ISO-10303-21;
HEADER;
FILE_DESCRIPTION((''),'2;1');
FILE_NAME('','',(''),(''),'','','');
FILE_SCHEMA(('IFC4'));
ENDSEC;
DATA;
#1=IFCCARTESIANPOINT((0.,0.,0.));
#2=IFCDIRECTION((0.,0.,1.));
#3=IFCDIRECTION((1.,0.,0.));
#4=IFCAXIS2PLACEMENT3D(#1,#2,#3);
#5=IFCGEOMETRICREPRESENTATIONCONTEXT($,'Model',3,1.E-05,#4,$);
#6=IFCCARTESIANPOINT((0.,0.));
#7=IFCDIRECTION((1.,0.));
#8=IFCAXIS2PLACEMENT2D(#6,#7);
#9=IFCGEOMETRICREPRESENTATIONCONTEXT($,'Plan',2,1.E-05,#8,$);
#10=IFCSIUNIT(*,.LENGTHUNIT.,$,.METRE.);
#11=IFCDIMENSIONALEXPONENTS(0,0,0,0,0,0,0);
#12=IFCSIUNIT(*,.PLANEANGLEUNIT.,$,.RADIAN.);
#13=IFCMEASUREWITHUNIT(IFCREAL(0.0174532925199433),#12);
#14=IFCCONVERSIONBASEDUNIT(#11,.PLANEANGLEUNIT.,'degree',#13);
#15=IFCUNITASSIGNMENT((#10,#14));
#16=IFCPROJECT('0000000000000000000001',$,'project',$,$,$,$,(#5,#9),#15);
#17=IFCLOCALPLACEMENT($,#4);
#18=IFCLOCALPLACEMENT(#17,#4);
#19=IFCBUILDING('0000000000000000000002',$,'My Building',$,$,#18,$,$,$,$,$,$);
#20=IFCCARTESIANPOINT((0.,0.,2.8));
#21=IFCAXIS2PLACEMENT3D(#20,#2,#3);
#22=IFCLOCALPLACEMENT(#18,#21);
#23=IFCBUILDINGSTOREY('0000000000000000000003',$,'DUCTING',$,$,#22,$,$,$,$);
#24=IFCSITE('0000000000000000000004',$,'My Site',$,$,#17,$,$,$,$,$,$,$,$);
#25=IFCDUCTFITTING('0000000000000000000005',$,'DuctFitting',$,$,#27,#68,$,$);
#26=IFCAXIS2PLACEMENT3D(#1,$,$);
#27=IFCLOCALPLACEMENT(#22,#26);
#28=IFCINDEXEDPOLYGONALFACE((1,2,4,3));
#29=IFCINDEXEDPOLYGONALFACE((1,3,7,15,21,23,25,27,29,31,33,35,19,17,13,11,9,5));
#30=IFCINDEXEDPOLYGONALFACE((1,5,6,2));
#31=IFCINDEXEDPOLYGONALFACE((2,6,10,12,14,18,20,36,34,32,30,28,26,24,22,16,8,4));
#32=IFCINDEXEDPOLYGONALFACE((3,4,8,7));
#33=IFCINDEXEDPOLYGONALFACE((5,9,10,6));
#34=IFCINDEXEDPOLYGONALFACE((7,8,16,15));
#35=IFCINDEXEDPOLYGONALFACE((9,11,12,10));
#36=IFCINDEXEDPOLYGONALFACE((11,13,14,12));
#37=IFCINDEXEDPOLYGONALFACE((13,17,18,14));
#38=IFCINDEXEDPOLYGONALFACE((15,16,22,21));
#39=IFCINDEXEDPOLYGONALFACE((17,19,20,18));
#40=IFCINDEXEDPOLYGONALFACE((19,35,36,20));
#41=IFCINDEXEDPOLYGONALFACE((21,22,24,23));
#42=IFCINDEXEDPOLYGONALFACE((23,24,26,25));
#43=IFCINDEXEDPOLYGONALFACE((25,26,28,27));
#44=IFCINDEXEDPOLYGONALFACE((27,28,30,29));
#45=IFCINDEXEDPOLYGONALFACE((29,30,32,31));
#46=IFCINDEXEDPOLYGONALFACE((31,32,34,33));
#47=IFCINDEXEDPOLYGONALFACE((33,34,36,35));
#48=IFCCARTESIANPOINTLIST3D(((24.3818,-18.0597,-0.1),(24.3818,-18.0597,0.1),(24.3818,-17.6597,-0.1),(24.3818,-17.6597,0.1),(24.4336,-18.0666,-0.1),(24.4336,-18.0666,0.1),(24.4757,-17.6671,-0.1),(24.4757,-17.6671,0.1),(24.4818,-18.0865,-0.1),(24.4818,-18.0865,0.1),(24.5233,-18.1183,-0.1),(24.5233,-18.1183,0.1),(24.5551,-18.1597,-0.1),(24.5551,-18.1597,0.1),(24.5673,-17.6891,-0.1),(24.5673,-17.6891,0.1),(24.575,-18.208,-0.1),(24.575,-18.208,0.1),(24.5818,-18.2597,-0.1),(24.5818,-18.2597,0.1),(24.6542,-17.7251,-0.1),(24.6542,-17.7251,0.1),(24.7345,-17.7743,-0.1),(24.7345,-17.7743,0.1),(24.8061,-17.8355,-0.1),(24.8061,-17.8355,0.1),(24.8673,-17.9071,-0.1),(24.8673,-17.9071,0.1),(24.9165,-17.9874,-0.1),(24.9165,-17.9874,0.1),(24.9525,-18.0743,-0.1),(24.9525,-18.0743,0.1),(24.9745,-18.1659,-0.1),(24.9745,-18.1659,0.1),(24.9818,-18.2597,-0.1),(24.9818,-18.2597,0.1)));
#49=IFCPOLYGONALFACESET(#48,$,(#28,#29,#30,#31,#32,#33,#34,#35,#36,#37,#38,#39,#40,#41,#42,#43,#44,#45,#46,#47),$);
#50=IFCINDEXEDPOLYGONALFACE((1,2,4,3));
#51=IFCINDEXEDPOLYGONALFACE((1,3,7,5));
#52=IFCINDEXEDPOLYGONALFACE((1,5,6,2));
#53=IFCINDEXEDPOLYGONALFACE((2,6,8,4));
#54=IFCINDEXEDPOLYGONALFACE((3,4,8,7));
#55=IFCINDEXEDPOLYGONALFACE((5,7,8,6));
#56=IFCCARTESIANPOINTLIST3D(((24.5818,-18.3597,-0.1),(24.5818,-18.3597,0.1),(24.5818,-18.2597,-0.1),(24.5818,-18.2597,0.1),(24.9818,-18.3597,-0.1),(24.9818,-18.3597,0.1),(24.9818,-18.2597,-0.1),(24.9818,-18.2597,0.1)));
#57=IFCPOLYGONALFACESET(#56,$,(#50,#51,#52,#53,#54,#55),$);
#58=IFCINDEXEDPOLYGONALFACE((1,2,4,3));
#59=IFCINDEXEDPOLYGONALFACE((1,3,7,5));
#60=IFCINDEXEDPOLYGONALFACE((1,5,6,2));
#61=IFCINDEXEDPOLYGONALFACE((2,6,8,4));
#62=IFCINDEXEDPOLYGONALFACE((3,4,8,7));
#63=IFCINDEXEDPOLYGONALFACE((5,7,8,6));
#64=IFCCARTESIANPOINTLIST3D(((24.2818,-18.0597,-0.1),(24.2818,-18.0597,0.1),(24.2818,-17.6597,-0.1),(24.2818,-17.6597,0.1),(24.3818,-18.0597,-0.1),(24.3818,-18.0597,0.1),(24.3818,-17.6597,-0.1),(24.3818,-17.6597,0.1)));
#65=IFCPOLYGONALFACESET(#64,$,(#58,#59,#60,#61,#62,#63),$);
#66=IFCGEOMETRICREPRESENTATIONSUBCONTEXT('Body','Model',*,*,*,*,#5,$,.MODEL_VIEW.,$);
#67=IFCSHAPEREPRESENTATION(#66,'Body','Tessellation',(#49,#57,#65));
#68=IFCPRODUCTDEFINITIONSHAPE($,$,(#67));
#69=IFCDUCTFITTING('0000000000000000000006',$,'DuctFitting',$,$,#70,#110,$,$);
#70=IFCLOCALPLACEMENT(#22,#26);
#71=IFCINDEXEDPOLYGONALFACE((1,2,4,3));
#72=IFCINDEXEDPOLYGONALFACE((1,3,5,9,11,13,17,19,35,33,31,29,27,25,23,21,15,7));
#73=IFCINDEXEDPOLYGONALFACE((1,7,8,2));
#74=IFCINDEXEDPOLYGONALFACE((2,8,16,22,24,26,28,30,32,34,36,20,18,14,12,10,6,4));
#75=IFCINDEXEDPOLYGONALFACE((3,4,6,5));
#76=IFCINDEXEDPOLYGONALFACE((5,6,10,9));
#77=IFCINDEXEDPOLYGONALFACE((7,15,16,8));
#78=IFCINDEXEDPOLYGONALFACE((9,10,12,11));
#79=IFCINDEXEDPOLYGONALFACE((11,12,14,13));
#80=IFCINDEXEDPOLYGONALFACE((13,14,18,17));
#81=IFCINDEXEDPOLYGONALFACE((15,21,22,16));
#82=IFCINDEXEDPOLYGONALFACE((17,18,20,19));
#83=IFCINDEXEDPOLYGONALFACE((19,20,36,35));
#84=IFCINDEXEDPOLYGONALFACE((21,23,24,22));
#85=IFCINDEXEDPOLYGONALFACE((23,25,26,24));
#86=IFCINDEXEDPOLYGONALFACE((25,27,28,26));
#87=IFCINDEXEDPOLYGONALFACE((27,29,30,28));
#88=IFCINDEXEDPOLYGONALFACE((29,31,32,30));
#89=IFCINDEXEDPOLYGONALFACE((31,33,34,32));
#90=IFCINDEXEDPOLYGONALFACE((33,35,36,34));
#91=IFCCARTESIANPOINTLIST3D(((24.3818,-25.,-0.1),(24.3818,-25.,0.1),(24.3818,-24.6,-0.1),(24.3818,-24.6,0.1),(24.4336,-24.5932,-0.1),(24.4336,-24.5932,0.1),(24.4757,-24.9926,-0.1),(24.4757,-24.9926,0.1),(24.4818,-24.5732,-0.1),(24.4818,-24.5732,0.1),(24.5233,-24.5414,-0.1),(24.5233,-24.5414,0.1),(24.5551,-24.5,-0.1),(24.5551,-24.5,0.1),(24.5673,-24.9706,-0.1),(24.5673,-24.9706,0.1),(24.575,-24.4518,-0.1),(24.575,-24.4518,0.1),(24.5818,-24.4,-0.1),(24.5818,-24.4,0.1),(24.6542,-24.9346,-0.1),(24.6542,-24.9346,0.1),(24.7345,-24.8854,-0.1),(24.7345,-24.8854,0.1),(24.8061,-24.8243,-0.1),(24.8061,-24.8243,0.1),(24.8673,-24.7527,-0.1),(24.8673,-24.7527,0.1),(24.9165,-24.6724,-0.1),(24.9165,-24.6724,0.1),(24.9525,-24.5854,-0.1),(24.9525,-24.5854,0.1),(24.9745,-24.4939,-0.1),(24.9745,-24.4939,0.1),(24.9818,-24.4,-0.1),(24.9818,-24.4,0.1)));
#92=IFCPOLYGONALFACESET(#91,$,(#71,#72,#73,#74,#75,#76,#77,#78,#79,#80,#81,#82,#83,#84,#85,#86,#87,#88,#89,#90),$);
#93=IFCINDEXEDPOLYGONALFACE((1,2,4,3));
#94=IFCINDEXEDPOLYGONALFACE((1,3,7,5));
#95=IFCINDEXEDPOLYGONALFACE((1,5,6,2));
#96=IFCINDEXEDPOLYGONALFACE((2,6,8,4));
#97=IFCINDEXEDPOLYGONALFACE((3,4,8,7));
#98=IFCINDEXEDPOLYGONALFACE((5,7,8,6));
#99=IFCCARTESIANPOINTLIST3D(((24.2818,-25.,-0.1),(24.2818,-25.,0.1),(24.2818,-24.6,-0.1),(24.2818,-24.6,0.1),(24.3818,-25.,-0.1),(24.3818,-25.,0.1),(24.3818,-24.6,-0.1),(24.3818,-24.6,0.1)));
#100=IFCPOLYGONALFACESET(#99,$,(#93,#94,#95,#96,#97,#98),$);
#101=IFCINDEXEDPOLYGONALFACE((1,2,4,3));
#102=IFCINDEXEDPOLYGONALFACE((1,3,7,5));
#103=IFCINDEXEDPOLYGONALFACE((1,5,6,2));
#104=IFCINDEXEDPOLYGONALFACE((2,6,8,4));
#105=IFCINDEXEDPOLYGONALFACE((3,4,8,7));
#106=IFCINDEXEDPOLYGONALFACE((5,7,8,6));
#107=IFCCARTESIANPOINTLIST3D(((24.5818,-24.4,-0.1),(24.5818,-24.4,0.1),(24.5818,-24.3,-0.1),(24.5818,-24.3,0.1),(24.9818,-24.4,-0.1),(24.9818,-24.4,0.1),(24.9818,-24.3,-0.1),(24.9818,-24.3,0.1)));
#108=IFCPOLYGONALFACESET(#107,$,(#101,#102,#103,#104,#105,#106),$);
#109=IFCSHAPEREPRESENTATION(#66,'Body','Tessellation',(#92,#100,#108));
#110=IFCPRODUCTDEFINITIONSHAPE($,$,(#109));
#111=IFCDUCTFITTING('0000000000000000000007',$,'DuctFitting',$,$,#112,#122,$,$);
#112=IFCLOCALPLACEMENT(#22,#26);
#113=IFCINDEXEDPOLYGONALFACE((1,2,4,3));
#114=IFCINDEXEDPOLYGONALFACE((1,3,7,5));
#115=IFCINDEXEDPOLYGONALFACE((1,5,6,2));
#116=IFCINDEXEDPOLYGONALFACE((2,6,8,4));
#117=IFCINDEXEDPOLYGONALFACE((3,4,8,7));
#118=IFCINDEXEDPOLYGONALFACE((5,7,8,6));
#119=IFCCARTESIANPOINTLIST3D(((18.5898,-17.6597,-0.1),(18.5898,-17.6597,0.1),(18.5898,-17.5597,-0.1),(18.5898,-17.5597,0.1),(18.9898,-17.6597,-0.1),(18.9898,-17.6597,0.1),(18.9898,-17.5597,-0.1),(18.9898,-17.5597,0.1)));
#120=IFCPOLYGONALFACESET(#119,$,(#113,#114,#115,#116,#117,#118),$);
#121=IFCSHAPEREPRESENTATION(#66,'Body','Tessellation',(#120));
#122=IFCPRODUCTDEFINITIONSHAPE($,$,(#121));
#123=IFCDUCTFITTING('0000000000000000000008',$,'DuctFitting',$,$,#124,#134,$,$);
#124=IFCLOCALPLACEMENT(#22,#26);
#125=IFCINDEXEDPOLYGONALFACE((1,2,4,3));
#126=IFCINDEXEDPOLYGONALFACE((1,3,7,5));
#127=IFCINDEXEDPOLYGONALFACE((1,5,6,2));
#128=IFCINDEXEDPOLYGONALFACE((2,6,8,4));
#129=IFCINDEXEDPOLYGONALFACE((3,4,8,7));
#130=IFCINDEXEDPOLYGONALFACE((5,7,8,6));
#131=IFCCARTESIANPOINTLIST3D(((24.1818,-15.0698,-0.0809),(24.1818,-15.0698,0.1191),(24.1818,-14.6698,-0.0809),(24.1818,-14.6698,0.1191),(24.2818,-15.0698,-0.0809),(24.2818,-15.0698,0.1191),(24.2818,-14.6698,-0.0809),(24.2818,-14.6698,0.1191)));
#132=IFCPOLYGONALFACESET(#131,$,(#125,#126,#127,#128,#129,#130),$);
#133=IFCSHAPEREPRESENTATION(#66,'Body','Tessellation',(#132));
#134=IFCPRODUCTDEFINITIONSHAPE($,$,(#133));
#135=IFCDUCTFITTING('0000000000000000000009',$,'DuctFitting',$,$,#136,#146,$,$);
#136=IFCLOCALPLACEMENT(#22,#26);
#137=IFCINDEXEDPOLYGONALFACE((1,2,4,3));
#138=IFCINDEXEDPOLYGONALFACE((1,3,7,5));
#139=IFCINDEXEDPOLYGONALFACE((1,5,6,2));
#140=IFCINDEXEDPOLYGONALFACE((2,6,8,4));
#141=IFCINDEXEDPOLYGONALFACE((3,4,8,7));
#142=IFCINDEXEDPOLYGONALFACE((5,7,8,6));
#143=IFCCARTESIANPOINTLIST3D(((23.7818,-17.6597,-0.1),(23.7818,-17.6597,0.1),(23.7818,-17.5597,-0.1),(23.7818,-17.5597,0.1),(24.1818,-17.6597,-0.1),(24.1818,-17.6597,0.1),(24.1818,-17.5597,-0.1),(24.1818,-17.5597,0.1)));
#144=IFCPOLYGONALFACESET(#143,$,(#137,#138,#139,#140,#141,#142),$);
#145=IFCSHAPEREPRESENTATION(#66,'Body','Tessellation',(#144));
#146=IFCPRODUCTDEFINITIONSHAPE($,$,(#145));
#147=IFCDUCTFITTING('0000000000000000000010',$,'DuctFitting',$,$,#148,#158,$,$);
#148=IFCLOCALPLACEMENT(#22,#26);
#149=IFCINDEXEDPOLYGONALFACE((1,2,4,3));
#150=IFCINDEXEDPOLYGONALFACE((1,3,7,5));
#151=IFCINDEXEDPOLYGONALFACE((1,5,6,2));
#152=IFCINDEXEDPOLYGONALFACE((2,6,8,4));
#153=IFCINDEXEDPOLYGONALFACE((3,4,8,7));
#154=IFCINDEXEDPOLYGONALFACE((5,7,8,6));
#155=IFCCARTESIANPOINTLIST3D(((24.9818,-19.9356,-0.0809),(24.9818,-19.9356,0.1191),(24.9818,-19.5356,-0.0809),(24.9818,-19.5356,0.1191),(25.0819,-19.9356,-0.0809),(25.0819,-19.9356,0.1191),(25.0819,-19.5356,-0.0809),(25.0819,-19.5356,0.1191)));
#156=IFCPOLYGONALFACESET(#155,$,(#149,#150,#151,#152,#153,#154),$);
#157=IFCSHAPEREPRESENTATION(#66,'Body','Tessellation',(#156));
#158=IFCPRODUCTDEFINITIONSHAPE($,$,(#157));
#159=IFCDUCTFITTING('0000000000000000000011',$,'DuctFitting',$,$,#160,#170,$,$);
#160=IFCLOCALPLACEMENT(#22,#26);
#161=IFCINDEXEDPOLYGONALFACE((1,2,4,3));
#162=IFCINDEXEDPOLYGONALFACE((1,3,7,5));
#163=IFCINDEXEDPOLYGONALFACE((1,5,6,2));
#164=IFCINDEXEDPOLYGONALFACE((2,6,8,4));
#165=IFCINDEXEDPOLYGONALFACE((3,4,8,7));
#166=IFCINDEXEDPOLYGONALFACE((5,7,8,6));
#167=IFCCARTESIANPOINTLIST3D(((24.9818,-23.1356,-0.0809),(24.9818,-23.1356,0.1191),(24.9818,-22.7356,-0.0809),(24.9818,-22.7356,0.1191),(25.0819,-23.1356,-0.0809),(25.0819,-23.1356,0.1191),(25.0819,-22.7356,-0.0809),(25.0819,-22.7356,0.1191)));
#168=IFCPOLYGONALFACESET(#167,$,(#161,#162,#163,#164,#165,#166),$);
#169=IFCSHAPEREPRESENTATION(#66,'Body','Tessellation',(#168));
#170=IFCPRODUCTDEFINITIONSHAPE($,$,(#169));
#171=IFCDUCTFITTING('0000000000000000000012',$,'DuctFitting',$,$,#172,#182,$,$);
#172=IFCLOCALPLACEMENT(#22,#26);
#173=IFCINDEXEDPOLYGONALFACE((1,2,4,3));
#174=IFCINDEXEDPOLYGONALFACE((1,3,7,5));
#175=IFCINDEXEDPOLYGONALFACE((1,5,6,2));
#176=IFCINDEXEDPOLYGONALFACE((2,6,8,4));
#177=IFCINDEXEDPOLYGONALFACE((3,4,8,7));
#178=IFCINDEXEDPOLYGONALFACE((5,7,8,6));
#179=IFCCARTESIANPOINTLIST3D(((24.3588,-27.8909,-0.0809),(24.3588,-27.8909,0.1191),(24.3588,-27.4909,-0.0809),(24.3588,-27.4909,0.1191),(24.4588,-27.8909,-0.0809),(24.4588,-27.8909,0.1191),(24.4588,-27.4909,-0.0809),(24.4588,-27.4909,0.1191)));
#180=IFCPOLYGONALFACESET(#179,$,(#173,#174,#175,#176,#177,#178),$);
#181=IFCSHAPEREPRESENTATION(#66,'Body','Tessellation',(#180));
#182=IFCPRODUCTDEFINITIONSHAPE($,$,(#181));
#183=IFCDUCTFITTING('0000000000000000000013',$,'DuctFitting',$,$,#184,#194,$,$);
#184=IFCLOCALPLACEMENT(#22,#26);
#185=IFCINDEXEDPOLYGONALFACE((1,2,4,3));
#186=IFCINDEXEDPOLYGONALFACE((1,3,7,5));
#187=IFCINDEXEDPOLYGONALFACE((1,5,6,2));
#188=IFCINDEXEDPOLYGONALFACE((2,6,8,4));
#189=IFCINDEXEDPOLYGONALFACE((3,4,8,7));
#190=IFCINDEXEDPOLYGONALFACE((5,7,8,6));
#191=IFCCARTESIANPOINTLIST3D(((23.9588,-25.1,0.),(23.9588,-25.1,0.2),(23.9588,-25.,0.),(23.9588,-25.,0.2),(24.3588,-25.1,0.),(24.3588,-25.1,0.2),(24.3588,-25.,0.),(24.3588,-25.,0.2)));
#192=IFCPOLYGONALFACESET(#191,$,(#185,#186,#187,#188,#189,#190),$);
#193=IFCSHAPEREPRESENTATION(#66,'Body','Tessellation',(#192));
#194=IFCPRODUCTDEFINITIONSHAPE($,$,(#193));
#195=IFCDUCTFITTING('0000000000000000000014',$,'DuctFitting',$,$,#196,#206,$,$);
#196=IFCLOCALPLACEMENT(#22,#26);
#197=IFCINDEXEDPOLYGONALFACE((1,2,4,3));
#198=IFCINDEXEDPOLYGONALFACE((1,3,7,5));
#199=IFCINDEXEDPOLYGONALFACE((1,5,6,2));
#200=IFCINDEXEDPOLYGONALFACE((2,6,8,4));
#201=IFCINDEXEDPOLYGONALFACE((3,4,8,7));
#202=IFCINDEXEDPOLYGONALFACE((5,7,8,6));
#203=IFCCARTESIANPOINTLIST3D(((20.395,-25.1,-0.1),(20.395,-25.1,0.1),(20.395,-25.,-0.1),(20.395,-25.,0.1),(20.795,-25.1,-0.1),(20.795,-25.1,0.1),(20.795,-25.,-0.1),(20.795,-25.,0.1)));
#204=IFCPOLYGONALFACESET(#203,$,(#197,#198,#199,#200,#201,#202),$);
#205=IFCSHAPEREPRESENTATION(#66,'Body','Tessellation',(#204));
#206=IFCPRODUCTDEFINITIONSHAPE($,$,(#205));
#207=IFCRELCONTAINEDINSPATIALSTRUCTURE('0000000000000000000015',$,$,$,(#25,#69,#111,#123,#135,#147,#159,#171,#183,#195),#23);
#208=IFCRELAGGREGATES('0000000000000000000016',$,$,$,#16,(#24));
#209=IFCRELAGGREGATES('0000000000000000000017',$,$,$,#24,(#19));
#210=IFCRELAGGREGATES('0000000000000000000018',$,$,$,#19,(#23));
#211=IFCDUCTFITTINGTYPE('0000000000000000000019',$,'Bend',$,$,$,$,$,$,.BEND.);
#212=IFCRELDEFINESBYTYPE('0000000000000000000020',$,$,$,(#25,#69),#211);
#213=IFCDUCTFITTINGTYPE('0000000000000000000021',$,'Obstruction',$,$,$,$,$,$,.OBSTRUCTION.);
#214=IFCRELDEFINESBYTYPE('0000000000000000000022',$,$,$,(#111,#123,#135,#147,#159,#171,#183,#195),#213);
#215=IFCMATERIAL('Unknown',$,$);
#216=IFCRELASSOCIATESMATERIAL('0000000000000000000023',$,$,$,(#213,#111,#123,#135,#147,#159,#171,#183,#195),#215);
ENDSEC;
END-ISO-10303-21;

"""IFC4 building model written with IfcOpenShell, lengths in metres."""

from ifc_helpers import new_model, entity, si_unit, converted_unit, frame, origin_with_axes, origin_2d_with_axis, place, context, subcontext, project, spatial, line, arc, indexed_curve, rectangle, outline, extrude, source, transform, mapped, material, material_profile, profile_set, profile_usage, type_object, type_shapes, element, save


model = new_model("IFC4")

# Units and contexts
model_context = context("Model", 3, precision=1e-05, world=origin_with_axes())
plan_context = context("Plan", 2, precision=1e-05, world=origin_2d_with_axis())
body_context = subcontext(model_context, "Body", "Model", "MODEL_VIEW")
ifc_project = project(units=[si_unit("LENGTHUNIT", "METRE"), converted_unit("PLANEANGLEUNIT", "degree", entity("IfcReal", 0.0174532925199433), si_unit("PLANEANGLEUNIT", "RADIAN"), dimensions=[0, 0, 0, 0, 0, 0, 0])], contexts=[model_context, plan_context])

# Site, building, storey
site_placement = place(None, origin_with_axes())
site = spatial("IfcSite", under=ifc_project, at=site_placement, Name="My Site")
building_placement = place(site_placement, origin_with_axes())
building = spatial("IfcBuilding", under=site, at=building_placement, Name="My Building")
storey_placement = place(building_placement, frame((0.0, 0.0, 2.8), z_axis=(0.0, 0.0, 1.0), x_axis=(1.0, 0.0, 0.0)))
storey = spatial("IfcBuildingStorey", under=building, at=storey_placement, Name="DUCTING")

# Shared definitions
ifc_material = material(Name="Unknown")

# Duct fittings
duct_fitting_type_1 = type_object("IfcDuctFittingType", Name="Bend", PredefinedType="BEND")
shared_shape = source(origin_with_axes(), body_context, "Body", "SweptSolid", [
    extrude(outline(indexed_curve([(0.2, 0.0), (0.2586, -0.1414), (0.4, -0.2), (0.4, -0.6), (-0.0243, -0.4243), (-0.2, 0.0)], segments=[arc(1, 2, 3), line(3, 4), arc(4, 5, 6), line(6, 1)])), frame((0.0, -0.1, -0.1), z_axis=(0.0, -1.0, 0.0), x_axis=(1.0, 0.0, 0.0)), (0.0, 0.0, -1.0), 0.2),
    extrude(rectangle(XDim=0.4, YDim=0.2), origin_with_axes(), (0.0, 0.0, -1.0), 0.1),
    extrude(rectangle(XDim=0.4, YDim=0.2), frame((0.4, 0.0, -0.5), z_axis=(1.0, 0.0, 0.0), x_axis=(0.0, 0.0, 1.0)), (0.0, 0.0, 1.0), 0.1),
])
type_shapes(duct_fitting_type_1, [shared_shape])
for number, where, z_axis, x_axis, name in (
    (1, (24.7818, -18.3597, 0.0), (0.0, -1.0, 0.0), (-1.0, 0.0, 0.0), "DuctFitting"),
    (2, (24.2818, -24.8, 0.0), (-1.0, 0.0, 0.0), (0.0, 1.0, 0.0), "DuctFitting"),
):
    element("IfcDuctFitting", number, at=place(storey_placement, frame(where, z_axis=z_axis, x_axis=x_axis)), inside=storey, type_object=duct_fitting_type_1, Name=name, context=body_context, shape_type="MappedRepresentation", body=[
        mapped(shared_shape, transform((0.0, 0.0, 0.0), x_axis=(1.0, 0.0, 0.0), y_axis=(0.0, 1.0, 0.0), z_axis=(0.0, 0.0, 1.0), scale=1.0)),
    ])
ifc_material_profile_1 = material_profile(ifc_material, rectangle(XDim=0.4, YDim=0.2))
ifc_profile_set_1 = profile_set([ifc_material_profile_1])
ifc_profile_usage_1 = profile_usage(ifc_profile_set_1, cardinal=5)
duct_fitting_type_2 = type_object("IfcDuctFittingType", Name="Obstruction", PredefinedType="OBSTRUCTION", material=ifc_profile_set_1)
duct_fitting_1_placement = place(storey_placement, frame((18.7898, -17.5597, 0.0), z_axis=(0.0, -1.0, 0.0), x_axis=(1.0, 0.0, 0.0)))
element("IfcDuctFitting", 3, at=duct_fitting_1_placement, inside=storey, type_object=duct_fitting_type_2, material=ifc_profile_usage_1, Name="DuctFitting", context=body_context, shape_type="SweptSolid", body=[
    extrude(rectangle(XDim=0.4, YDim=0.2), origin_with_axes(), (0.0, 0.0, 1.0), 0.1),
])
ifc_profile_usage_2 = profile_usage(ifc_profile_set_1, cardinal=5)
duct_fitting_2_placement = place(storey_placement, frame((24.2818, -14.8698, 0.0191), z_axis=(-1.0, 0.0, 0.0), x_axis=(0.0, -1.0, 0.0)))
element("IfcDuctFitting", 4, at=duct_fitting_2_placement, inside=storey, type_object=duct_fitting_type_2, material=ifc_profile_usage_2, Name="DuctFitting", context=body_context, shape_type="SweptSolid", body=[
    extrude(rectangle(XDim=0.4, YDim=0.2), origin_with_axes(), (0.0, 0.0, 1.0), 0.1),
])
ifc_profile_usage_3 = profile_usage(ifc_profile_set_1, cardinal=5)
duct_fitting_3_placement = place(storey_placement, frame((23.9818, -17.5597, 0.0), z_axis=(0.0, -1.0, 0.0), x_axis=(1.0, 0.0, 0.0)))
element("IfcDuctFitting", 5, at=duct_fitting_3_placement, inside=storey, type_object=duct_fitting_type_2, material=ifc_profile_usage_3, Name="DuctFitting", context=body_context, shape_type="SweptSolid", body=[
    extrude(rectangle(XDim=0.4, YDim=0.2), origin_with_axes(), (0.0, 0.0, 1.0), 0.1),
])
ifc_profile_usage_4 = profile_usage(ifc_profile_set_1, cardinal=5)
duct_fitting_4_placement = place(storey_placement, frame((25.0819, -19.7356, 0.0191), z_axis=(-1.0, 0.0, 0.0), x_axis=(0.0, -1.0, 0.0)))
element("IfcDuctFitting", 6, at=duct_fitting_4_placement, inside=storey, type_object=duct_fitting_type_2, material=ifc_profile_usage_4, Name="DuctFitting", context=body_context, shape_type="SweptSolid", body=[
    extrude(rectangle(XDim=0.4, YDim=0.2), origin_with_axes(), (0.0, 0.0, 1.0), 0.1),
])
ifc_profile_usage_5 = profile_usage(ifc_profile_set_1, cardinal=5)
duct_fitting_5_placement = place(storey_placement, frame((25.0819, -22.9356, 0.0191), z_axis=(-1.0, 0.0, 0.0), x_axis=(0.0, -1.0, 0.0)))
element("IfcDuctFitting", 7, at=duct_fitting_5_placement, inside=storey, type_object=duct_fitting_type_2, material=ifc_profile_usage_5, Name="DuctFitting", context=body_context, shape_type="SweptSolid", body=[
    extrude(rectangle(XDim=0.4, YDim=0.2), origin_with_axes(), (0.0, 0.0, 1.0), 0.1),
])
ifc_profile_usage_6 = profile_usage(ifc_profile_set_1, cardinal=5)
duct_fitting_6_placement = place(storey_placement, frame((24.4588, -27.6909, 0.0191), z_axis=(-1.0, 0.0, 0.0), x_axis=(0.0, -1.0, 0.0)))
element("IfcDuctFitting", 8, at=duct_fitting_6_placement, inside=storey, type_object=duct_fitting_type_2, material=ifc_profile_usage_6, Name="DuctFitting", context=body_context, shape_type="SweptSolid", body=[
    extrude(rectangle(XDim=0.4, YDim=0.2), origin_with_axes(), (0.0, 0.0, 1.0), 0.1),
])
ifc_profile_usage_7 = profile_usage(ifc_profile_set_1, cardinal=5)
duct_fitting_7_placement = place(storey_placement, frame((24.1588, -25.0, 0.1), z_axis=(0.0, -1.0, 0.0), x_axis=(1.0, 0.0, 0.0)))
element("IfcDuctFitting", 9, at=duct_fitting_7_placement, inside=storey, type_object=duct_fitting_type_2, material=ifc_profile_usage_7, Name="DuctFitting", context=body_context, shape_type="SweptSolid", body=[
    extrude(rectangle(XDim=0.4, YDim=0.2), origin_with_axes(), (0.0, 0.0, 1.0), 0.1),
])
ifc_profile_usage_8 = profile_usage(ifc_profile_set_1, cardinal=5)
duct_fitting_8_placement = place(storey_placement, frame((20.595, -25.0, 0.0), z_axis=(0.0, -1.0, 0.0), x_axis=(1.0, 0.0, 0.0)))
element("IfcDuctFitting", 10, at=duct_fitting_8_placement, inside=storey, type_object=duct_fitting_type_2, material=ifc_profile_usage_8, Name="DuctFitting", context=body_context, shape_type="SweptSolid", body=[
    extrude(rectangle(XDim=0.4, YDim=0.2), origin_with_axes(), (0.0, 0.0, 1.0), 0.1),
])

save(model, "model.ifc")
